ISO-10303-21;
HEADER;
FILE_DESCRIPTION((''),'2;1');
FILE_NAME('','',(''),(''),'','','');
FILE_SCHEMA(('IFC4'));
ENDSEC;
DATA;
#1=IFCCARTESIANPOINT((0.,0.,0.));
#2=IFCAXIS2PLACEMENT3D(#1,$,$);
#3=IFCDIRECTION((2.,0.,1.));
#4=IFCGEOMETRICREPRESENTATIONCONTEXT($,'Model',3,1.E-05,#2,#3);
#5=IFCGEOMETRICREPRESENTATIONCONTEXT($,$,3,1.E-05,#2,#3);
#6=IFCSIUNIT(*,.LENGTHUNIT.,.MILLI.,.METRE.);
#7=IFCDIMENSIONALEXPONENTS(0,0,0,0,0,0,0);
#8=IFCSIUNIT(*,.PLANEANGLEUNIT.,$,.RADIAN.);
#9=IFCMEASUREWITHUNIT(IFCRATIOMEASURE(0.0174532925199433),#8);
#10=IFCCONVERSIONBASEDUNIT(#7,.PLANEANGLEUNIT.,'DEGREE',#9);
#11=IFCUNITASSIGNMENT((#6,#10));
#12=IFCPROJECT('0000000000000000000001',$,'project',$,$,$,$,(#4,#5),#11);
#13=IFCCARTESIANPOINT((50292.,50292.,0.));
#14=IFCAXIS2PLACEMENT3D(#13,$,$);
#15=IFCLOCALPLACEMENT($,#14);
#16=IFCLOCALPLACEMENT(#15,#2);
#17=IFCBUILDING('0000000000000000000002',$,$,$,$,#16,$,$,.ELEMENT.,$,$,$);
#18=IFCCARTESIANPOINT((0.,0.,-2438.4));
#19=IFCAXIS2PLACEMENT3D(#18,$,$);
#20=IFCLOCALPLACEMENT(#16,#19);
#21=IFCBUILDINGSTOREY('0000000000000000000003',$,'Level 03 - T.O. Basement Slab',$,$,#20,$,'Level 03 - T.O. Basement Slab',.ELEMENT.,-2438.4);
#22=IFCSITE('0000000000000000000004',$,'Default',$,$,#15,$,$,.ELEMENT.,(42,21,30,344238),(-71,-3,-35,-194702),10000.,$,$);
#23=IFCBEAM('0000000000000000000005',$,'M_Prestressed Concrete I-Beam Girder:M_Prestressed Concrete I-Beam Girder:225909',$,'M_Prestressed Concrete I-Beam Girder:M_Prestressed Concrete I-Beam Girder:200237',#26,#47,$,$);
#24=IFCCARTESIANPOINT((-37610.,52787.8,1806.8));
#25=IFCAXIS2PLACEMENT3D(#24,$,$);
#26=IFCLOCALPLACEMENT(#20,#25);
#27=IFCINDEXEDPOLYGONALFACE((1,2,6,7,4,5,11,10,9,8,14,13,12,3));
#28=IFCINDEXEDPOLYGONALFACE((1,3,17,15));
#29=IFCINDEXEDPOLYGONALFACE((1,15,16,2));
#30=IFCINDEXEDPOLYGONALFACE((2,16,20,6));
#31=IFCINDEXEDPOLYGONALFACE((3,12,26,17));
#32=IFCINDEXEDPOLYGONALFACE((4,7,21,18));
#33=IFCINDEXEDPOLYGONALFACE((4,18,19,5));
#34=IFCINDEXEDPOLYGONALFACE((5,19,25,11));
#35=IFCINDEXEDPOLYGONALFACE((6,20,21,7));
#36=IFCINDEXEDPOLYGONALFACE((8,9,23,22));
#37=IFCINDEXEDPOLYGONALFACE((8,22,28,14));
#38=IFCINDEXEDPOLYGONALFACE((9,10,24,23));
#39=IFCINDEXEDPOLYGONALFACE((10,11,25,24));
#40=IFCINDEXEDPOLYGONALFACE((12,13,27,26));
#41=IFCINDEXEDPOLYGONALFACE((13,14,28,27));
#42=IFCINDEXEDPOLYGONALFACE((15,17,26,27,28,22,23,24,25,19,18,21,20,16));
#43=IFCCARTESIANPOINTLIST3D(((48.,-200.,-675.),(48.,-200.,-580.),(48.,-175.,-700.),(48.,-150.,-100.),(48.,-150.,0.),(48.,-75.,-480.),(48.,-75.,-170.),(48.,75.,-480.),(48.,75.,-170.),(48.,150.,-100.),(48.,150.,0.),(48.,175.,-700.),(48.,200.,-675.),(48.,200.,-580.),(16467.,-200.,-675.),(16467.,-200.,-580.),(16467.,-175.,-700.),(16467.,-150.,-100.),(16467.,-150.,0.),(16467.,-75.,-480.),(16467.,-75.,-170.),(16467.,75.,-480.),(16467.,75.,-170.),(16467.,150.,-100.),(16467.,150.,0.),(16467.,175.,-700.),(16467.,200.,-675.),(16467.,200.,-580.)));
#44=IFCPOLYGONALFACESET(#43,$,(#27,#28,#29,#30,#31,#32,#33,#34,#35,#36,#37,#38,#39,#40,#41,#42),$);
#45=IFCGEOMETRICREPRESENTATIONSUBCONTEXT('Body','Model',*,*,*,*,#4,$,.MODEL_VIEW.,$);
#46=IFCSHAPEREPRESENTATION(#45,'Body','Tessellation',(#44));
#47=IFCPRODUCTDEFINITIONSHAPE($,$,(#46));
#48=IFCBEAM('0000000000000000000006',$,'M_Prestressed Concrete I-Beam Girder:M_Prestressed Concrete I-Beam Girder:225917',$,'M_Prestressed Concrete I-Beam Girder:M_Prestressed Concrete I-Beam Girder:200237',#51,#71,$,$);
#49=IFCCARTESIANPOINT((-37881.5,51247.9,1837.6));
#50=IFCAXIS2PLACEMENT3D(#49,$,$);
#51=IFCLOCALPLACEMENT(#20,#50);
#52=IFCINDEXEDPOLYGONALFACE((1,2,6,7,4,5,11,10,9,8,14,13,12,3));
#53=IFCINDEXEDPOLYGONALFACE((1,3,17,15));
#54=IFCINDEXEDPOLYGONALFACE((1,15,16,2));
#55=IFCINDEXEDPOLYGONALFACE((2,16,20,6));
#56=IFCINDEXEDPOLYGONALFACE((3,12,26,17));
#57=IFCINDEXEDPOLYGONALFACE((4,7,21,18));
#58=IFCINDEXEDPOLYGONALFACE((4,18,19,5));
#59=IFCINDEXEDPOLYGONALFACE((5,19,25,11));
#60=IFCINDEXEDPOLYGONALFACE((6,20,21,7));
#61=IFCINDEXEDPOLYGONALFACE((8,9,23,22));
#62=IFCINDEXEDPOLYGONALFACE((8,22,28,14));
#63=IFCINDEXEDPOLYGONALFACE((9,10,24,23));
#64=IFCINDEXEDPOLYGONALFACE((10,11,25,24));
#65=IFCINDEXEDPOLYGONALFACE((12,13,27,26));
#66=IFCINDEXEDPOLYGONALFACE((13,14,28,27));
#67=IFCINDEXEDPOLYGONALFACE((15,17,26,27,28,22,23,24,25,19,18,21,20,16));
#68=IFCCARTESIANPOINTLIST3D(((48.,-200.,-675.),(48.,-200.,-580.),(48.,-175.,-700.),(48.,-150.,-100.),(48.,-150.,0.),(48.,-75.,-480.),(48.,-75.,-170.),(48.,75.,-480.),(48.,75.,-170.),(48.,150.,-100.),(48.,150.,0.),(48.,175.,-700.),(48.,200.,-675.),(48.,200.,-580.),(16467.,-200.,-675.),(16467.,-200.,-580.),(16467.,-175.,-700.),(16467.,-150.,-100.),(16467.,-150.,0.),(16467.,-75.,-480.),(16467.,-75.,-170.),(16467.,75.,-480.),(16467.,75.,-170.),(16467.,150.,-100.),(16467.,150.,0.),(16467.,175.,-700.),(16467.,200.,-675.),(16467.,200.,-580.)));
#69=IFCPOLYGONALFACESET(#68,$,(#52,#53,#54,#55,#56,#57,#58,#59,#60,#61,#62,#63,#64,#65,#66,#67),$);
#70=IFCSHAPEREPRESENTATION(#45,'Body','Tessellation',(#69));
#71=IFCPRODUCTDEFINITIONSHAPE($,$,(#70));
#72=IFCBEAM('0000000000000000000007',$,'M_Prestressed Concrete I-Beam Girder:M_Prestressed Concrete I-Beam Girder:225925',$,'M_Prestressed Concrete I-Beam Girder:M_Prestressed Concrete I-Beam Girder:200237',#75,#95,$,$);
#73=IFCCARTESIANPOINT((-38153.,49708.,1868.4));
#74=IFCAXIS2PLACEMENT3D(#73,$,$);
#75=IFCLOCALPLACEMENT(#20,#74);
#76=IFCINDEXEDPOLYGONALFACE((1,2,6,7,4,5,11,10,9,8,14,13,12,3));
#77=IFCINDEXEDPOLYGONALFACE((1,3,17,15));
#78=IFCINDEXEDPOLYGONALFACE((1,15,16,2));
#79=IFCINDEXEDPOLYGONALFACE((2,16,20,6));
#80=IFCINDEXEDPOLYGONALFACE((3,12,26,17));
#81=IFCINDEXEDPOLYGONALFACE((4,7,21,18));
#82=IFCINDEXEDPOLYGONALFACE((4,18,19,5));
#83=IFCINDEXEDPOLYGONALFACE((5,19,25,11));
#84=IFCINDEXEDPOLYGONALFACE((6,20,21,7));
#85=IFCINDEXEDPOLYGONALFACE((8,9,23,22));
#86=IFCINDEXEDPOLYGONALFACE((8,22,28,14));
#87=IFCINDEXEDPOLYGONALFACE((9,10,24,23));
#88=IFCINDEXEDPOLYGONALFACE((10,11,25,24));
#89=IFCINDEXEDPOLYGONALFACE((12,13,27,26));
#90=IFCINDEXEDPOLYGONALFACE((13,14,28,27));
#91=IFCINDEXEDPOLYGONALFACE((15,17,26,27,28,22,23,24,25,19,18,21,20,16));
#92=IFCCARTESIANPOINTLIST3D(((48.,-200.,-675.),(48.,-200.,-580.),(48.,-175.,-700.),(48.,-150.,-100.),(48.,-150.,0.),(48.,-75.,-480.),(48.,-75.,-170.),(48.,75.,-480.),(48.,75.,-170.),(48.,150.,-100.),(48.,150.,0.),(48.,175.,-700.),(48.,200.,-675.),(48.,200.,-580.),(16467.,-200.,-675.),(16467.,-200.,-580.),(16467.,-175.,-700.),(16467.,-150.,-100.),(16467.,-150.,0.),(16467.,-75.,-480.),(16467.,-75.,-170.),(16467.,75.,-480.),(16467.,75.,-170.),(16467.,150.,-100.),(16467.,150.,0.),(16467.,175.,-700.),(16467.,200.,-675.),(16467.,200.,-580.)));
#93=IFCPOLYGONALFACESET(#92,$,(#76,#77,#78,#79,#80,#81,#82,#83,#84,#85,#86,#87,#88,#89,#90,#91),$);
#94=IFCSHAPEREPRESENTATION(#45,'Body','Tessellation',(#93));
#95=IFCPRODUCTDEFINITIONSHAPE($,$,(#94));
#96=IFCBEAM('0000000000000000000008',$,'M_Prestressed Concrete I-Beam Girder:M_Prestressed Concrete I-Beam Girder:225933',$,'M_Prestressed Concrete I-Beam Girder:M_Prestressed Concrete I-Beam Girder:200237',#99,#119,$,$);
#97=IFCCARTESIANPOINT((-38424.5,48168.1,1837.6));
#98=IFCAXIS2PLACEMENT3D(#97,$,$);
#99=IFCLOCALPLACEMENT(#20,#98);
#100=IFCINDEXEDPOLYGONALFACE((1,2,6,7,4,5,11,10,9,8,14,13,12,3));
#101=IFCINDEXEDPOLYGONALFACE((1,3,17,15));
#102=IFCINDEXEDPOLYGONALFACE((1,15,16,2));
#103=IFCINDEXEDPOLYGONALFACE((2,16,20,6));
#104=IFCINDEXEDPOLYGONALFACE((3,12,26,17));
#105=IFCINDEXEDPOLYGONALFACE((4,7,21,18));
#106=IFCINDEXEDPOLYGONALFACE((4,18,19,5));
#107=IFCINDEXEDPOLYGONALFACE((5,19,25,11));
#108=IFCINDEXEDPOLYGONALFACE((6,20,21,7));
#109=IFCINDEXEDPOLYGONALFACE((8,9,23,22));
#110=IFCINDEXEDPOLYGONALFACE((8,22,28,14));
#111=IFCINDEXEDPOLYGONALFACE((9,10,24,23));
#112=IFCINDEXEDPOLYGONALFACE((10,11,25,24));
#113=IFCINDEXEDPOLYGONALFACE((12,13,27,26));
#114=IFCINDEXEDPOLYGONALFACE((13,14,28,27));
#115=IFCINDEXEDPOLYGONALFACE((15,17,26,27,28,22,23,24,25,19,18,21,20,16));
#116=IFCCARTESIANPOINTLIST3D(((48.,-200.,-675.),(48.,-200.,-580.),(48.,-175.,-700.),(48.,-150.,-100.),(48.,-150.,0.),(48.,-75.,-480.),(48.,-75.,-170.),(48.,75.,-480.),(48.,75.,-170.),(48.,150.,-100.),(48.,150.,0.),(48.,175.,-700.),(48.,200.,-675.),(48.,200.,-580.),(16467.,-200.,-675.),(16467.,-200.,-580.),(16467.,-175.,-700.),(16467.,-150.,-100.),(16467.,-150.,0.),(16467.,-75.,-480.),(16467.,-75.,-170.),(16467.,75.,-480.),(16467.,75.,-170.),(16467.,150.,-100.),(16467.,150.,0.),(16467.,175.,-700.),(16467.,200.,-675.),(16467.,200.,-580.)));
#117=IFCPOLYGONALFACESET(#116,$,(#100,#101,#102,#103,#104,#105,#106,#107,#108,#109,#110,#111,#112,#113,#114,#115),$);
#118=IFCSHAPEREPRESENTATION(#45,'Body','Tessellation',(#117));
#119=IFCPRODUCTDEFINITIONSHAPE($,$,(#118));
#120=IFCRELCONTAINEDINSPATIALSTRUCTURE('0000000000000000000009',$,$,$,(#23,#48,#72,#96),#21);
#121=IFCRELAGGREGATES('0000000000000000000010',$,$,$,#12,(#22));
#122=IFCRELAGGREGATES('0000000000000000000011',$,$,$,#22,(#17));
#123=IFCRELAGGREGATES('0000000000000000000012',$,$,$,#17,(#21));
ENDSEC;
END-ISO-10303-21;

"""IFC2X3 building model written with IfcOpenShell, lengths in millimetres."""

from ifc_helpers import new_model, entity, si_unit, converted_unit, direction, frame, origin, place, context, subcontext, project, spatial, polyline, outline, extrude, element, save


model = new_model("IFC2X3")

# Units and contexts
model_context = context("Model", 3, precision=1e-05, world=origin(), true_north=direction((2.0, 0.0, 1.0)))
context_of_model = context(None, 3, precision=1e-05, world=origin(), true_north=direction((2.0, 0.0, 1.0)))
body_context = subcontext(model_context, "Body", "Model", "MODEL_VIEW")
ifc_project = project(units=[si_unit("LENGTHUNIT", "METRE", prefix="MILLI"), converted_unit("PLANEANGLEUNIT", "DEGREE", entity("IfcRatioMeasure", 0.0174532925199433), si_unit("PLANEANGLEUNIT", "RADIAN"), dimensions=[0, 0, 0, 0, 0, 0, 0])], contexts=[model_context, context_of_model])

# Site, building, storey
site_placement = place(None, frame((50292.0, 50292.0, 0.0)))
site = spatial("IfcSite", under=ifc_project, at=site_placement, Name="Default", CompositionType="ELEMENT", RefLatitude=(42, 21, 30, 344238), RefLongitude=(-71, -3, -35, -194702), RefElevation=10000.0)
building_placement = place(site_placement, origin())
building = spatial("IfcBuilding", under=site, at=building_placement, CompositionType="ELEMENT")
storey_placement = place(building_placement, frame((0.0, 0.0, -2438.4)))
storey = spatial("IfcBuildingStorey", under=building, at=storey_placement, Name="Level 03 - T.O. Basement Slab", LongName="Level 03 - T.O. Basement Slab", CompositionType="ELEMENT", Elevation=-2438.4)

# Beams
beam_1_placement = place(storey_placement, frame((-37610.0, 52787.8, 1806.8)))
element("IfcBeam", 1, at=beam_1_placement, inside=storey, Name="M_Prestressed Concrete I-Beam Girder:M_Prestressed Concrete I-Beam Girder:225909", ObjectType="M_Prestressed Concrete I-Beam Girder:M_Prestressed Concrete I-Beam Girder:200237", context=body_context, shape_type="SweptSolid", body=[
    extrude(outline(polyline([(193.6, -200.0), (288.6, -200.0), (313.6, -175.0), (313.6, 175.0), (288.6, 200.0), (193.6, 200.0), (93.6, 75.0), (-216.4, 75.0), (-286.4, 150.0), (-386.4, 150.0), (-386.4, -150.0), (-286.4, -150.0), (-216.4, -75.0), (93.6, -75.0), (193.6, -200.0)])), frame((48.0, 0.0, -386.4), z_axis=(1.0, 0.0, 0.0), x_axis=(0.0, 0.0, -1.0)), (0.0, 0.0, 1.0), 16419.0),
])
beam_2_placement = place(storey_placement, frame((-37881.5, 51247.9, 1837.6)))
element("IfcBeam", 2, at=beam_2_placement, inside=storey, Name="M_Prestressed Concrete I-Beam Girder:M_Prestressed Concrete I-Beam Girder:225917", ObjectType="M_Prestressed Concrete I-Beam Girder:M_Prestressed Concrete I-Beam Girder:200237", context=body_context, shape_type="SweptSolid", body=[
    extrude(outline(polyline([(193.6, -200.0), (288.6, -200.0), (313.6, -175.0), (313.6, 175.0), (288.6, 200.0), (193.6, 200.0), (93.6, 75.0), (-216.4, 75.0), (-286.4, 150.0), (-386.4, 150.0), (-386.4, -150.0), (-286.4, -150.0), (-216.4, -75.0), (93.6, -75.0), (193.6, -200.0)])), frame((48.0, 0.0, -386.4), z_axis=(1.0, 0.0, 0.0), x_axis=(0.0, 0.0, -1.0)), (0.0, 0.0, 1.0), 16419.0),
])
beam_3_placement = place(storey_placement, frame((-38153.0, 49708.0, 1868.4)))
element("IfcBeam", 3, at=beam_3_placement, inside=storey, Name="M_Prestressed Concrete I-Beam Girder:M_Prestressed Concrete I-Beam Girder:225925", ObjectType="M_Prestressed Concrete I-Beam Girder:M_Prestressed Concrete I-Beam Girder:200237", context=body_context, shape_type="SweptSolid", body=[
    extrude(outline(polyline([(193.6, -200.0), (288.6, -200.0), (313.6, -175.0), (313.6, 175.0), (288.6, 200.0), (193.6, 200.0), (93.6, 75.0), (-216.4, 75.0), (-286.4, 150.0), (-386.4, 150.0), (-386.4, -150.0), (-286.4, -150.0), (-216.4, -75.0), (93.6, -75.0), (193.6, -200.0)])), frame((48.0, 0.0, -386.4), z_axis=(1.0, 0.0, 0.0), x_axis=(0.0, 0.0, -1.0)), (0.0, 0.0, 1.0), 16419.0),
])
beam_4_placement = place(storey_placement, frame((-38424.5, 48168.1, 1837.6)))
element("IfcBeam", 4, at=beam_4_placement, inside=storey, Name="M_Prestressed Concrete I-Beam Girder:M_Prestressed Concrete I-Beam Girder:225933", ObjectType="M_Prestressed Concrete I-Beam Girder:M_Prestressed Concrete I-Beam Girder:200237", context=body_context, shape_type="SweptSolid", body=[
    extrude(outline(polyline([(193.6, -200.0), (288.6, -200.0), (313.6, -175.0), (313.6, 175.0), (288.6, 200.0), (193.6, 200.0), (93.6, 75.0), (-216.4, 75.0), (-286.4, 150.0), (-386.4, 150.0), (-386.4, -150.0), (-286.4, -150.0), (-216.4, -75.0), (93.6, -75.0), (193.6, -200.0)])), frame((48.0, 0.0, -386.4), z_axis=(1.0, 0.0, 0.0), x_axis=(0.0, 0.0, -1.0)), (0.0, 0.0, 1.0), 16419.0),
])

save(model, "model.ifc")
